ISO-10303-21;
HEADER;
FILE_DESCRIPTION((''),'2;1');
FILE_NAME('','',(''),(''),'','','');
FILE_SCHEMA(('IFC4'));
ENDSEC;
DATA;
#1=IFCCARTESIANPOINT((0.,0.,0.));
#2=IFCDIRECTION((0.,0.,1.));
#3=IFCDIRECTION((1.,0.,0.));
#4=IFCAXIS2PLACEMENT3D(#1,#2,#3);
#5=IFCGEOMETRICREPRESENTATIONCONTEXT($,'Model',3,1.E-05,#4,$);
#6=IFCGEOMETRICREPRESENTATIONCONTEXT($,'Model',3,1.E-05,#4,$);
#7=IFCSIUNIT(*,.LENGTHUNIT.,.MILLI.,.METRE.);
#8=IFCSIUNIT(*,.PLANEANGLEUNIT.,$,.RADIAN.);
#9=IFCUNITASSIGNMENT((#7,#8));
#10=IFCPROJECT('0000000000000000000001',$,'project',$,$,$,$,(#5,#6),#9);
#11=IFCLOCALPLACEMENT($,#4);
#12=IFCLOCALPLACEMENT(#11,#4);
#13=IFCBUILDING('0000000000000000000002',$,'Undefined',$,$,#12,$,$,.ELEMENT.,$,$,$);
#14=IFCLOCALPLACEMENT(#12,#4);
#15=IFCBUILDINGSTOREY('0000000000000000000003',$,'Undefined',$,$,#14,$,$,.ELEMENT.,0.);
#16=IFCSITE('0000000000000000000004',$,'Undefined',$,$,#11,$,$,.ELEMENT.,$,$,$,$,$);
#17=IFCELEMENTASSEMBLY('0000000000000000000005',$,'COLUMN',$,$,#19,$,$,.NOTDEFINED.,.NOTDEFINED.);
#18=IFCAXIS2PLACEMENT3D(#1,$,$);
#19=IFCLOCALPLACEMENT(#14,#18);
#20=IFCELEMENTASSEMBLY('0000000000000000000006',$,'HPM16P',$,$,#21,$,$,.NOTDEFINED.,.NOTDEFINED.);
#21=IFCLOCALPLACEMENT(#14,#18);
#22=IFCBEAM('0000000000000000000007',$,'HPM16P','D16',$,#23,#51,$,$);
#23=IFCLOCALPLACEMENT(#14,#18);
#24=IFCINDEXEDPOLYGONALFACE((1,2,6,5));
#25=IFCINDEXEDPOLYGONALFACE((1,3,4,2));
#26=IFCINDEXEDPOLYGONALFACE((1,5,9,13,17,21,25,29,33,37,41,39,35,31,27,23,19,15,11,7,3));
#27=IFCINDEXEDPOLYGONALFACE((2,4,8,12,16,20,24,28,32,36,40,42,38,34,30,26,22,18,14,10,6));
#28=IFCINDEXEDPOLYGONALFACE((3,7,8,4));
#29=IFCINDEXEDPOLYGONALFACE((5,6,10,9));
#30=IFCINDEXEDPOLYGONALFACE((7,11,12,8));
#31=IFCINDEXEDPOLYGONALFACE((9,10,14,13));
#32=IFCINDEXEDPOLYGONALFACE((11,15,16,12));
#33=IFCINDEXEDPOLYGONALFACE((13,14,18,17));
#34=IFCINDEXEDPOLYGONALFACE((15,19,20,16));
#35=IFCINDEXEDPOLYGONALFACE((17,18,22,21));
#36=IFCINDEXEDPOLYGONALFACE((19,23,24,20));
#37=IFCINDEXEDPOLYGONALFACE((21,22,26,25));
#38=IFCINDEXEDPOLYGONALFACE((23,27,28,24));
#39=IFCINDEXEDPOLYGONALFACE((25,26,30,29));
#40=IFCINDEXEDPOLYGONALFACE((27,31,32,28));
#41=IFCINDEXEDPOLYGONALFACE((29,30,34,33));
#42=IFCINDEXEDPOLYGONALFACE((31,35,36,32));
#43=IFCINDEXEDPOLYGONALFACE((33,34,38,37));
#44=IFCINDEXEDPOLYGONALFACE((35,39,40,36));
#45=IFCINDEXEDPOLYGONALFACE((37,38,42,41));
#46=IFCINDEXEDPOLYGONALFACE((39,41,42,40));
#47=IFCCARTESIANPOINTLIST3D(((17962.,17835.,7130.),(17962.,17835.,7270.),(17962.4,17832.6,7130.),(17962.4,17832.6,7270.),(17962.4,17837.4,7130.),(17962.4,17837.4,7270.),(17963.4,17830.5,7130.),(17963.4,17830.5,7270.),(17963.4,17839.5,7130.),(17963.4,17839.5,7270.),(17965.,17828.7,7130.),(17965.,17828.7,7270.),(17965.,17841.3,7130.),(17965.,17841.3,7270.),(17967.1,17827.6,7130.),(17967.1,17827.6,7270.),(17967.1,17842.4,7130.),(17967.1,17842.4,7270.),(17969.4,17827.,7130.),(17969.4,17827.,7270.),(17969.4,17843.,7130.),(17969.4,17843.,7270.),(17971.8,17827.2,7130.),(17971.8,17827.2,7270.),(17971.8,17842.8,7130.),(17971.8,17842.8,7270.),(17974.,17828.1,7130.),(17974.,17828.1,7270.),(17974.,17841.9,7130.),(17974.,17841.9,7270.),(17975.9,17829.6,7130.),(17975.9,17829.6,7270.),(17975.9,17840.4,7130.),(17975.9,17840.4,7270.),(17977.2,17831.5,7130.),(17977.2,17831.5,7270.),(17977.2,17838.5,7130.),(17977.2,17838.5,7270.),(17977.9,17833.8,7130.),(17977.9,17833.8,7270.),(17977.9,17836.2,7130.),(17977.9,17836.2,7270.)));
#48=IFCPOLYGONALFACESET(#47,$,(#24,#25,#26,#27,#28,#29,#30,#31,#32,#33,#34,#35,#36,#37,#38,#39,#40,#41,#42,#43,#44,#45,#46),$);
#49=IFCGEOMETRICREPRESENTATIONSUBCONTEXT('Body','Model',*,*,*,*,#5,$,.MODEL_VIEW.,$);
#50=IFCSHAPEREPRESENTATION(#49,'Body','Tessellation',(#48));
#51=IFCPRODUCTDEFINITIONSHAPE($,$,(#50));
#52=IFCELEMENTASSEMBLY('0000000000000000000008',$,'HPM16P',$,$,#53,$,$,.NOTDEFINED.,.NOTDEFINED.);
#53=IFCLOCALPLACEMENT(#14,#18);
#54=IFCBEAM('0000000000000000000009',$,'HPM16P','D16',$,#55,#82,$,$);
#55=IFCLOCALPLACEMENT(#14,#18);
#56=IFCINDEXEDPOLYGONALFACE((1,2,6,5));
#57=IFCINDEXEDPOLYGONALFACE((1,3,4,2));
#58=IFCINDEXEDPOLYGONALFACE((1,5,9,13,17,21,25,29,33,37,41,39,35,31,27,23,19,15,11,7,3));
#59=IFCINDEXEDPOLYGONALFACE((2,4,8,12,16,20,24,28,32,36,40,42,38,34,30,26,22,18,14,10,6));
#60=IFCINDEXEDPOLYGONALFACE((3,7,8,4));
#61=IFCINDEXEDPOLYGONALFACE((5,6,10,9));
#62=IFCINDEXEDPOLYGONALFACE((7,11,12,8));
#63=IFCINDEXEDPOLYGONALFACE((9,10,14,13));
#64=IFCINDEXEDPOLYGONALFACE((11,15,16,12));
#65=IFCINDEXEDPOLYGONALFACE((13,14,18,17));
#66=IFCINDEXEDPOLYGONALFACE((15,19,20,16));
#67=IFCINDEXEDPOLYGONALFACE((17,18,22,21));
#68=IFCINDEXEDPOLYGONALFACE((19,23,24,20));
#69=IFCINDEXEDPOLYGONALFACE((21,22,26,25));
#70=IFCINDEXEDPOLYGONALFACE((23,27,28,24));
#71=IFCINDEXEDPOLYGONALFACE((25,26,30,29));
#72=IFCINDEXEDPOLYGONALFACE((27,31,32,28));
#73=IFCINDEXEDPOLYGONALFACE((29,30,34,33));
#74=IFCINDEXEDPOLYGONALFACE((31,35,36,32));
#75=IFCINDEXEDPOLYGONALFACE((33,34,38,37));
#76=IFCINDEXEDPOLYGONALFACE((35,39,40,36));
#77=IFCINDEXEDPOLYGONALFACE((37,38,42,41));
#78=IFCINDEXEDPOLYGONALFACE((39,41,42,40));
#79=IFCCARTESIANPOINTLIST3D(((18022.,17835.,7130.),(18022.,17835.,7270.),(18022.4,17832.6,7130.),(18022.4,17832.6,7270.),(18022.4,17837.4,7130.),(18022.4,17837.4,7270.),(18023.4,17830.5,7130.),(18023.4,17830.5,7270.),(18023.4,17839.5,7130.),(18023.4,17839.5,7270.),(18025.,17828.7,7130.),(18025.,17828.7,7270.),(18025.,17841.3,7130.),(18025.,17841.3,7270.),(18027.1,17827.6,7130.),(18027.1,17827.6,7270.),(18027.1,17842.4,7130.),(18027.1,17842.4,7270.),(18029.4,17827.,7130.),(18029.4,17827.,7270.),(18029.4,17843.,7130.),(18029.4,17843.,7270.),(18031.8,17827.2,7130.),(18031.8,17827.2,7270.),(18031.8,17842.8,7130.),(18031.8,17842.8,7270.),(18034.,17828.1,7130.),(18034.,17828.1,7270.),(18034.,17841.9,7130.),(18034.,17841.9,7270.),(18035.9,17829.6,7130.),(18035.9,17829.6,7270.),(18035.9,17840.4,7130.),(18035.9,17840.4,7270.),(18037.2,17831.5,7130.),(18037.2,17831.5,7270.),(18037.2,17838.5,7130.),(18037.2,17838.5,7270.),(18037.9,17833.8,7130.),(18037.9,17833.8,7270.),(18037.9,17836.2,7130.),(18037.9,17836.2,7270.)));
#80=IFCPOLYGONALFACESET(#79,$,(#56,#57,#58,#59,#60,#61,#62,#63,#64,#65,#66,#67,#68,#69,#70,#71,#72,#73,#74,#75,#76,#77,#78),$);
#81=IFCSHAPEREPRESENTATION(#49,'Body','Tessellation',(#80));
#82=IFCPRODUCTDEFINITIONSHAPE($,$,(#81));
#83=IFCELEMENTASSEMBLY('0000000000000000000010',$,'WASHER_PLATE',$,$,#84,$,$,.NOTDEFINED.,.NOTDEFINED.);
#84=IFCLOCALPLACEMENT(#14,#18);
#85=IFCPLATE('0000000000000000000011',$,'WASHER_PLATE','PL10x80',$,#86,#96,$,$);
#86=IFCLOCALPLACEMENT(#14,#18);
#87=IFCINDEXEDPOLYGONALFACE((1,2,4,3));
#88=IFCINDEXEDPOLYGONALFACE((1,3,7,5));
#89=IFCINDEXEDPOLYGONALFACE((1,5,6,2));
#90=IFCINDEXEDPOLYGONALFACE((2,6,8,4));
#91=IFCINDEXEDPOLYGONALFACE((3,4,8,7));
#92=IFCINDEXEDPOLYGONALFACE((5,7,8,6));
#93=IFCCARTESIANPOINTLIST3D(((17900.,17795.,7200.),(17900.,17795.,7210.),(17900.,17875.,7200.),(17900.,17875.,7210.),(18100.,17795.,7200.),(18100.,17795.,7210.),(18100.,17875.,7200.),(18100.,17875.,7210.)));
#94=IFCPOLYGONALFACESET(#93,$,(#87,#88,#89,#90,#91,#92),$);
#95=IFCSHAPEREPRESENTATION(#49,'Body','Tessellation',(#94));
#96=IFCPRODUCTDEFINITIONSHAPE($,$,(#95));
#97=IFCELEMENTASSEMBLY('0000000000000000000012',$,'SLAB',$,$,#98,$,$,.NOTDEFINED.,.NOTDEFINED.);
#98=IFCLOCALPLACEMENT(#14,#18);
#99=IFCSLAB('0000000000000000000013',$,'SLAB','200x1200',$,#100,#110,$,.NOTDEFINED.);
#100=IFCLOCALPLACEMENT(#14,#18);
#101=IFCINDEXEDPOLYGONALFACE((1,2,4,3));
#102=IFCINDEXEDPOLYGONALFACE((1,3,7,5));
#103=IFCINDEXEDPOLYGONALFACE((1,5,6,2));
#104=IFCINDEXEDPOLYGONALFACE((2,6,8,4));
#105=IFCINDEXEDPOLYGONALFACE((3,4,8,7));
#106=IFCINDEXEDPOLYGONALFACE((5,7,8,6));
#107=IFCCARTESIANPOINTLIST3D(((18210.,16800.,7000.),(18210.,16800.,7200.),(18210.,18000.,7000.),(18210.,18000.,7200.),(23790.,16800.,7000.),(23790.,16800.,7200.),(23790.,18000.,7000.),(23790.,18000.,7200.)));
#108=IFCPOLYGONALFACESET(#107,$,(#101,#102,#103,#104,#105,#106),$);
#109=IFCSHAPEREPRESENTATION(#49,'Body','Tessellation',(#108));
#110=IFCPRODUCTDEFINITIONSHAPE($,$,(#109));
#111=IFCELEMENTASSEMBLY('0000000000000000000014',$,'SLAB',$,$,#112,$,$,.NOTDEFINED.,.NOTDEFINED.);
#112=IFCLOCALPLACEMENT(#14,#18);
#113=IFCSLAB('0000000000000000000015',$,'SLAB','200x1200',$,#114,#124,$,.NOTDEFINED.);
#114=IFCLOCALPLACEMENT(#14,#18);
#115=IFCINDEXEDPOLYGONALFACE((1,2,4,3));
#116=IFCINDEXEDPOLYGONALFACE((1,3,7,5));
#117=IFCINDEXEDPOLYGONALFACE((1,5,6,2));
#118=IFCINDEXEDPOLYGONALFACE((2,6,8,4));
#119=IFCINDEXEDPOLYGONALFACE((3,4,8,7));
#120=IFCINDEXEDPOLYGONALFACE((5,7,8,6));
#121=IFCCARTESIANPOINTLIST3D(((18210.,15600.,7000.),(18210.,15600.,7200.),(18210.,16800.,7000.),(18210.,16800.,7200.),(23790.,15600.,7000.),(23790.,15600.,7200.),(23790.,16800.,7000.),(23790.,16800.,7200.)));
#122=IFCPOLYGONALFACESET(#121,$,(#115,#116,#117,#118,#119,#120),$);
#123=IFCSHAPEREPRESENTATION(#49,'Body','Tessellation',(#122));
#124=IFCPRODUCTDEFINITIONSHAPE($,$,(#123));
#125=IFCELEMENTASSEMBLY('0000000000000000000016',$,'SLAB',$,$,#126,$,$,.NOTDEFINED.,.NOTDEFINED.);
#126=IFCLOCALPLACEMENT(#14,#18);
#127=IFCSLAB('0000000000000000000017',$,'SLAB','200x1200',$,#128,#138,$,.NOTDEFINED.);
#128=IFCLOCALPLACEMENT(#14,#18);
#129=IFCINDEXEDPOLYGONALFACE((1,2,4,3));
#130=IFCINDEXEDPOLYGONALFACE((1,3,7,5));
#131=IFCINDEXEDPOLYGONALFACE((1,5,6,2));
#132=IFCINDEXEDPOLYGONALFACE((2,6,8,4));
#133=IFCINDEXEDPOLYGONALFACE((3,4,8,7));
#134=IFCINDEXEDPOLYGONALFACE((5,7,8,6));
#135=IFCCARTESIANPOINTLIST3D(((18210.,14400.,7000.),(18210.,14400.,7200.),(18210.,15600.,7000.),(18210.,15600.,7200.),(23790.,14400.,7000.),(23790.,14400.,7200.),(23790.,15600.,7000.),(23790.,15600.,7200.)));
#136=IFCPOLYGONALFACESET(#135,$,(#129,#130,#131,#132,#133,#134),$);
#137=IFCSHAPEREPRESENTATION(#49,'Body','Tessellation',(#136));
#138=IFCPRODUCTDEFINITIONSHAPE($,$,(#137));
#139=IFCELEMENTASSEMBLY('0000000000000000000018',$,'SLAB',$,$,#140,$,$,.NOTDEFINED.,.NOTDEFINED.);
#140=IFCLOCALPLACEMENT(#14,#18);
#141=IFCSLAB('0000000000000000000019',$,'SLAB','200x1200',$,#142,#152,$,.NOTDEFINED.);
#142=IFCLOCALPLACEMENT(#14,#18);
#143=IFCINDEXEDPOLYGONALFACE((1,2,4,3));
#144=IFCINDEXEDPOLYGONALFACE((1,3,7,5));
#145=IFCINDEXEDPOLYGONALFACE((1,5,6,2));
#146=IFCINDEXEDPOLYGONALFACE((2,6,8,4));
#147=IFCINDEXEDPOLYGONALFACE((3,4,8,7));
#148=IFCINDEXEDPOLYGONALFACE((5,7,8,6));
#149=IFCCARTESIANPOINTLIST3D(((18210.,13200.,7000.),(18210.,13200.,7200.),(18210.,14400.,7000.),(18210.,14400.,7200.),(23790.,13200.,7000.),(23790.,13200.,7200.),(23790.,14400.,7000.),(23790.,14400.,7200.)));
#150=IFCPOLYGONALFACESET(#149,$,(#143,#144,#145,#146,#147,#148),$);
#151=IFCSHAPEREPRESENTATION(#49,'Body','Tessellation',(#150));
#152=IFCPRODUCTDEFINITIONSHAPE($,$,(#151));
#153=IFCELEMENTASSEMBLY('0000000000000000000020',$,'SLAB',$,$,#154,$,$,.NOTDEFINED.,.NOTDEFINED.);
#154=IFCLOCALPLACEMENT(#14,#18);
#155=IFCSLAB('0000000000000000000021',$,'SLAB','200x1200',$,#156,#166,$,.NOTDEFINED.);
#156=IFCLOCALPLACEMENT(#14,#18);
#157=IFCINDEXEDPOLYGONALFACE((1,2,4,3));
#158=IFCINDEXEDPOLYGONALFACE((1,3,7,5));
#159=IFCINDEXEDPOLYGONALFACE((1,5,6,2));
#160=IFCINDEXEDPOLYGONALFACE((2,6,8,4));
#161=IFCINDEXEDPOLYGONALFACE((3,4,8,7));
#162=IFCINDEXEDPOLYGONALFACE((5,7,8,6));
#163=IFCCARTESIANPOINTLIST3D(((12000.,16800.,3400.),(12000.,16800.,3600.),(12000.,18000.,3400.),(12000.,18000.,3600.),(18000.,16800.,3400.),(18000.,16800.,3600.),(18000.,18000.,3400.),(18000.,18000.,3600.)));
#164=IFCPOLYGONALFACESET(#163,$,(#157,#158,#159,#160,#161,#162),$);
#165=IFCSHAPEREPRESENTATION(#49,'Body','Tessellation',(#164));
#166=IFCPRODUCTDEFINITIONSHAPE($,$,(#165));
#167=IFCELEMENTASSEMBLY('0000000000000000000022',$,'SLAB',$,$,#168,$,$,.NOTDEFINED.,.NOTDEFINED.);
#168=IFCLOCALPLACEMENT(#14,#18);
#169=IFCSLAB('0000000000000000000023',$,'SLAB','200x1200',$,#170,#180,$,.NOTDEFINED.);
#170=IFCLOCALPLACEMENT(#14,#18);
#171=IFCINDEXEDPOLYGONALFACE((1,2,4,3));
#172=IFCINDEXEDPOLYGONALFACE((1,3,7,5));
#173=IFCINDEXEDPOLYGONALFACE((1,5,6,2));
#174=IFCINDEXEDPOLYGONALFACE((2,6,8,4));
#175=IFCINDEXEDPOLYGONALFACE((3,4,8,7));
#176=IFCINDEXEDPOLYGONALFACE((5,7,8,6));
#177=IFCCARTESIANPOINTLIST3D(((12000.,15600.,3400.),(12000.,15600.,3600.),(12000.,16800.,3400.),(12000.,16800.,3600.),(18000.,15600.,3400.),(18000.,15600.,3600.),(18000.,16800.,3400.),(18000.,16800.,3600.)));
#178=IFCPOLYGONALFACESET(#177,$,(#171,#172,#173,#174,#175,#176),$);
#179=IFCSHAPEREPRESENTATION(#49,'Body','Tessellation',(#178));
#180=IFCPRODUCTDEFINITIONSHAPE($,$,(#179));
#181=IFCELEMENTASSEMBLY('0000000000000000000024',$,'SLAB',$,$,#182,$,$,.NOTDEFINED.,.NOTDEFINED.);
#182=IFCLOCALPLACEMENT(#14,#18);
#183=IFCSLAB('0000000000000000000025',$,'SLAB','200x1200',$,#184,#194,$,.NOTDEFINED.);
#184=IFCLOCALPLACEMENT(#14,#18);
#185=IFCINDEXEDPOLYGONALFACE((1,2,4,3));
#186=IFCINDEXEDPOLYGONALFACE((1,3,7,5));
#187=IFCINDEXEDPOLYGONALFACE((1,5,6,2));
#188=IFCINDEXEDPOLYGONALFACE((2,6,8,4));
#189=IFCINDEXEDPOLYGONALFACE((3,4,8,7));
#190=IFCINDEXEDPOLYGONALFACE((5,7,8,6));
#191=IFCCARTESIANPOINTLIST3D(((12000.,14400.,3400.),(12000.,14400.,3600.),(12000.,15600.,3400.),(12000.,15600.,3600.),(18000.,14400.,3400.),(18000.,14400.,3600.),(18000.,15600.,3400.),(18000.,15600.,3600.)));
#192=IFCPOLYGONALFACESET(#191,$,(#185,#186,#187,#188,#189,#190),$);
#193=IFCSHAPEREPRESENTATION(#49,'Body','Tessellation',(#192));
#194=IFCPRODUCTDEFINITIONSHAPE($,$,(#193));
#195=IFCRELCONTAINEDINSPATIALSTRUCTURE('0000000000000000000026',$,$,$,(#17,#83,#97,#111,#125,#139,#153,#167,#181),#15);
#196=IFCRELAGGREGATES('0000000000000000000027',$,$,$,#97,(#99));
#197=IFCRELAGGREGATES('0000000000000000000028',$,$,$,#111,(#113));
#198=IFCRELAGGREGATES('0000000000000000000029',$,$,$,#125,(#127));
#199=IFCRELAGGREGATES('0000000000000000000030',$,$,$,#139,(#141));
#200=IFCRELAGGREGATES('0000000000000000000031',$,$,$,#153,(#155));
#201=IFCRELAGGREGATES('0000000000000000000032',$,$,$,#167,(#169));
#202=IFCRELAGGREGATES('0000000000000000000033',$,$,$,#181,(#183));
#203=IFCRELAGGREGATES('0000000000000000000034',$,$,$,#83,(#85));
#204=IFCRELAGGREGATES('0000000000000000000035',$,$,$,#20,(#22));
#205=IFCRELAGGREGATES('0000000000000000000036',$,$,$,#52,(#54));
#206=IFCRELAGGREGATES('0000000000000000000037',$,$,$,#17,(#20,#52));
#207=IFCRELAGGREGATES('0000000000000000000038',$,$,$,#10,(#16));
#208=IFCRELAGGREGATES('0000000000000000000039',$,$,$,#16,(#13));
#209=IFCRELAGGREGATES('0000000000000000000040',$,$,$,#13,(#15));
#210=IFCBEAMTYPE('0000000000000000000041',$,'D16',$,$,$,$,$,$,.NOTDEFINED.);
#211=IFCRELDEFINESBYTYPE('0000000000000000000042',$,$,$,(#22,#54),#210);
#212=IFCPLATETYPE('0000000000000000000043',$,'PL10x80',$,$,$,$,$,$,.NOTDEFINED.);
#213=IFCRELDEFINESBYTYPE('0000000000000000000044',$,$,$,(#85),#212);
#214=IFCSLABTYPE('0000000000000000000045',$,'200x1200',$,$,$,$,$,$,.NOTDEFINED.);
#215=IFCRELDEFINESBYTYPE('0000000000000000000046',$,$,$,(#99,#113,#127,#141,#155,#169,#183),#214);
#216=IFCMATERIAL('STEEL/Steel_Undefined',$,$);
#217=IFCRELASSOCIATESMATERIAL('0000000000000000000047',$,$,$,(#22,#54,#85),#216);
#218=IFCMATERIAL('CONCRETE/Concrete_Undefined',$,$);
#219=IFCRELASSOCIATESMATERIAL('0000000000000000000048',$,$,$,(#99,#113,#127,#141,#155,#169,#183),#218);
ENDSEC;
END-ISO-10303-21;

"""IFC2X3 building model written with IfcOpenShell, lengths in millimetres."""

from ifc_helpers import new_model, si_unit, frame, origin_with_axes, origin_2d_with_axis, place, context, subcontext, project, spatial, polyline, circle, outline, extrude, material, type_object, element, aggregate, save


model = new_model("IFC2X3")

# Units and contexts
model_context_1 = context("Model", 3, precision=1e-05, world=origin_with_axes())
model_context_2 = context("Model", 3, precision=1e-05, world=origin_with_axes())
body_context = subcontext(model_context_1, "Body", "Model", "MODEL_VIEW")
ifc_project = project(units=[si_unit("LENGTHUNIT", "METRE", prefix="MILLI"), si_unit("PLANEANGLEUNIT", "RADIAN")], contexts=[model_context_1, model_context_2])

# Site, building, storey
site_placement = place(None, origin_with_axes())
site = spatial("IfcSite", under=ifc_project, at=site_placement, Name="Undefined", CompositionType="ELEMENT")
building_placement = place(site_placement, origin_with_axes())
building = spatial("IfcBuilding", under=site, at=building_placement, Name="Undefined", CompositionType="ELEMENT")
storey_placement = place(building_placement, origin_with_axes())
storey = spatial("IfcBuildingStorey", under=building, at=storey_placement, Name="Undefined", CompositionType="ELEMENT", Elevation=0.0)

# Element assemblies, beams
assembly_1_placement = place(storey_placement, origin_with_axes())
assembly_1 = element("IfcElementAssembly", 1, at=assembly_1_placement, inside=storey, Name="COLUMN", AssemblyPlace="NOTDEFINED", PredefinedType="NOTDEFINED")
assembly_2_placement = place(assembly_1_placement, origin_with_axes())
assembly_2 = element("IfcElementAssembly", 2, at=assembly_2_placement, Name="HPM16P", AssemblyPlace="NOTDEFINED", PredefinedType="NOTDEFINED")
ifc_material_1 = material(Name="STEEL/Steel_Undefined")
beam_type = type_object("IfcBeamType", Name="D16", PredefinedType="NOTDEFINED")
beam_1_placement = place(assembly_2_placement, frame((17970.0, 17835.0, 7270.0), z_axis=(0.0, -1.0, 0.0), x_axis=(0.0, 0.0, -1.0)))
beam_1 = element("IfcBeam", 3, at=beam_1_placement, type_object=beam_type, material=ifc_material_1, Name="HPM16P", Description="D16", context=body_context, shape_type="SweptSolid", body=[
    extrude(circle(Radius=8.0, at=origin_2d_with_axis()), frame((140.0, 0.0, 0.0), z_axis=(-1.0, 0.0, 0.0), x_axis=(0.0, -1.0, 0.0)), (0.0, 0.0, 1.0), 140.0),
])
assembly_3_placement = place(assembly_1_placement, origin_with_axes())
assembly_3 = element("IfcElementAssembly", 4, at=assembly_3_placement, Name="HPM16P", AssemblyPlace="NOTDEFINED", PredefinedType="NOTDEFINED")
beam_2_placement = place(assembly_3_placement, frame((18030.0, 17835.0, 7270.0), z_axis=(0.0, -1.0, 0.0), x_axis=(0.0, 0.0, -1.0)))
beam_2 = element("IfcBeam", 5, at=beam_2_placement, type_object=beam_type, material=ifc_material_1, Name="HPM16P", Description="D16", context=body_context, shape_type="SweptSolid", body=[
    extrude(circle(Radius=8.0, at=origin_2d_with_axis()), frame((140.0, 0.0, 0.0), z_axis=(-1.0, 0.0, 0.0), x_axis=(0.0, -1.0, 0.0)), (0.0, 0.0, 1.0), 140.0),
])

# Element assembly, plate
assembly_4_placement = place(storey_placement, origin_with_axes())
assembly_4 = element("IfcElementAssembly", 6, at=assembly_4_placement, inside=storey, Name="WASHER_PLATE", AssemblyPlace="NOTDEFINED", PredefinedType="NOTDEFINED")
plate_type_1 = type_object("IfcPlateType", Name="PL10x80", PredefinedType="NOTDEFINED")
plate_1_placement = place(assembly_4_placement, frame((18100.0, 17875.0, 7205.0), z_axis=(0.0, 0.0, -1.0), x_axis=(0.0, -1.0, 0.0)))
plate_1 = element("IfcPlate", 7, at=plate_1_placement, type_object=plate_type_1, material=ifc_material_1, Name="WASHER_PLATE", Description="PL10x80", context=body_context, shape_type="SweptSolid", body=[
    extrude(outline(polyline([(0.0, 0.0), (80.0, 0.0), (80.0, 200.0), (0.0, 200.0), (0.0, 0.0)])), frame((0.0, 0.0, -5.0), z_axis=(0.0, 0.0, 1.0), x_axis=(1.0, 0.0, 0.0)), (0.0, 0.0, 1.0), 10.0),
])

# Element assemblies, slabs
assembly_5_placement = place(storey_placement, origin_with_axes())
assembly_5 = element("IfcElementAssembly", 8, at=assembly_5_placement, inside=storey, Name="SLAB", AssemblyPlace="NOTDEFINED", PredefinedType="NOTDEFINED")
ifc_material_2 = material(Name="CONCRETE/Concrete_Undefined")
slab_type = type_object("IfcSlabType", Name="200x1200", PredefinedType="NOTDEFINED")
slab_1_placement = place(assembly_5_placement, frame((23790.0, 16800.0, 7100.0), z_axis=(0.0, 0.0, 1.0), x_axis=(0.0, 1.0, 0.0)))
slab_1 = element("IfcSlab", 9, at=slab_1_placement, type_object=slab_type, material=ifc_material_2, Name="SLAB", Description="200x1200", PredefinedType="NOTDEFINED", context=body_context, shape_type="SweptSolid", body=[
    extrude(outline(polyline([(0.0, 0.0), (1200.0, 0.0), (1200.0, 5580.0), (0.0, 5580.0), (0.0, 0.0)])), frame((0.0, 0.0, -100.0), z_axis=(0.0, 0.0, 1.0), x_axis=(1.0, 0.0, 0.0)), (0.0, 0.0, 1.0), 200.0),
])
aggregate(assembly_5, [slab_1])
assembly_6_placement = place(storey_placement, origin_with_axes())
assembly_6 = element("IfcElementAssembly", 10, at=assembly_6_placement, inside=storey, Name="SLAB", AssemblyPlace="NOTDEFINED", PredefinedType="NOTDEFINED")
slab_2_placement = place(assembly_6_placement, frame((23790.0, 15600.0, 7100.0), z_axis=(0.0, 0.0, 1.0), x_axis=(0.0, 1.0, 0.0)))
slab_2 = element("IfcSlab", 11, at=slab_2_placement, type_object=slab_type, material=ifc_material_2, Name="SLAB", Description="200x1200", PredefinedType="NOTDEFINED", context=body_context, shape_type="SweptSolid", body=[
    extrude(outline(polyline([(0.0, 0.0), (1200.0, 0.0), (1200.0, 5580.0), (0.0, 5580.0), (0.0, 0.0)])), frame((0.0, 0.0, -100.0), z_axis=(0.0, 0.0, 1.0), x_axis=(1.0, 0.0, 0.0)), (0.0, 0.0, 1.0), 200.0),
])
aggregate(assembly_6, [slab_2])
assembly_7_placement = place(storey_placement, origin_with_axes())
assembly_7 = element("IfcElementAssembly", 12, at=assembly_7_placement, inside=storey, Name="SLAB", AssemblyPlace="NOTDEFINED", PredefinedType="NOTDEFINED")
slab_3_placement = place(assembly_7_placement, frame((23790.0, 14400.0, 7100.0), z_axis=(0.0, 0.0, 1.0), x_axis=(0.0, 1.0, 0.0)))
slab_3 = element("IfcSlab", 13, at=slab_3_placement, type_object=slab_type, material=ifc_material_2, Name="SLAB", Description="200x1200", PredefinedType="NOTDEFINED", context=body_context, shape_type="SweptSolid", body=[
    extrude(outline(polyline([(0.0, 0.0), (1200.0, 0.0), (1200.0, 5580.0), (0.0, 5580.0), (0.0, 0.0)])), frame((0.0, 0.0, -100.0), z_axis=(0.0, 0.0, 1.0), x_axis=(1.0, 0.0, 0.0)), (0.0, 0.0, 1.0), 200.0),
])
aggregate(assembly_7, [slab_3])
assembly_8_placement = place(storey_placement, origin_with_axes())
assembly_8 = element("IfcElementAssembly", 14, at=assembly_8_placement, inside=storey, Name="SLAB", AssemblyPlace="NOTDEFINED", PredefinedType="NOTDEFINED")
slab_4_placement = place(assembly_8_placement, frame((23790.0, 13200.0, 7100.0), z_axis=(0.0, 0.0, 1.0), x_axis=(0.0, 1.0, 0.0)))
slab_4 = element("IfcSlab", 15, at=slab_4_placement, type_object=slab_type, material=ifc_material_2, Name="SLAB", Description="200x1200", PredefinedType="NOTDEFINED", context=body_context, shape_type="SweptSolid", body=[
    extrude(outline(polyline([(0.0, 0.0), (1200.0, 0.0), (1200.0, 5580.0), (0.0, 5580.0), (0.0, 0.0)])), frame((0.0, 0.0, -100.0), z_axis=(0.0, 0.0, 1.0), x_axis=(1.0, 0.0, 0.0)), (0.0, 0.0, 1.0), 200.0),
])
aggregate(assembly_8, [slab_4])
assembly_9_placement = place(storey_placement, origin_with_axes())
assembly_9 = element("IfcElementAssembly", 16, at=assembly_9_placement, inside=storey, Name="SLAB", AssemblyPlace="NOTDEFINED", PredefinedType="NOTDEFINED")
slab_5_placement = place(assembly_9_placement, frame((18000.0, 16800.0, 3500.0), z_axis=(0.0, 0.0, 1.0), x_axis=(0.0, 1.0, 0.0)))
slab_5 = element("IfcSlab", 17, at=slab_5_placement, type_object=slab_type, material=ifc_material_2, Name="SLAB", Description="200x1200", PredefinedType="NOTDEFINED", context=body_context, shape_type="SweptSolid", body=[
    extrude(outline(polyline([(0.0, 0.0), (1200.0, 0.0), (1200.0, 6000.0), (0.0, 6000.0), (0.0, 0.0)])), frame((0.0, 0.0, -100.0), z_axis=(0.0, 0.0, 1.0), x_axis=(1.0, 0.0, 0.0)), (0.0, 0.0, 1.0), 200.0),
])
aggregate(assembly_9, [slab_5])
assembly_10_placement = place(storey_placement, origin_with_axes())
assembly_10 = element("IfcElementAssembly", 18, at=assembly_10_placement, inside=storey, Name="SLAB", AssemblyPlace="NOTDEFINED", PredefinedType="NOTDEFINED")
slab_6_placement = place(assembly_10_placement, frame((18000.0, 15600.0, 3500.0), z_axis=(0.0, 0.0, 1.0), x_axis=(0.0, 1.0, 0.0)))
slab_6 = element("IfcSlab", 19, at=slab_6_placement, type_object=slab_type, material=ifc_material_2, Name="SLAB", Description="200x1200", PredefinedType="NOTDEFINED", context=body_context, shape_type="SweptSolid", body=[
    extrude(outline(polyline([(0.0, 0.0), (1200.0, 0.0), (1200.0, 6000.0), (0.0, 6000.0), (0.0, 0.0)])), frame((0.0, 0.0, -100.0), z_axis=(0.0, 0.0, 1.0), x_axis=(1.0, 0.0, 0.0)), (0.0, 0.0, 1.0), 200.0),
])
aggregate(assembly_10, [slab_6])
assembly_11_placement = place(storey_placement, origin_with_axes())
assembly_11 = element("IfcElementAssembly", 20, at=assembly_11_placement, inside=storey, Name="SLAB", AssemblyPlace="NOTDEFINED", PredefinedType="NOTDEFINED")
slab_7_placement = place(assembly_11_placement, frame((18000.0, 14400.0, 3500.0), z_axis=(0.0, 0.0, 1.0), x_axis=(0.0, 1.0, 0.0)))
slab_7 = element("IfcSlab", 21, at=slab_7_placement, type_object=slab_type, material=ifc_material_2, Name="SLAB", Description="200x1200", PredefinedType="NOTDEFINED", context=body_context, shape_type="SweptSolid", body=[
    extrude(outline(polyline([(0.0, 0.0), (1200.0, 0.0), (1200.0, 6000.0), (0.0, 6000.0), (0.0, 0.0)])), frame((0.0, 0.0, -100.0), z_axis=(0.0, 0.0, 1.0), x_axis=(1.0, 0.0, 0.0)), (0.0, 0.0, 1.0), 200.0),
])
aggregate(assembly_11, [slab_7])

aggregate(assembly_4, [plate_1])

aggregate(assembly_2, [beam_1])
aggregate(assembly_3, [beam_2])

aggregate(assembly_1, [assembly_2, assembly_3])

save(model, "model.ifc")
